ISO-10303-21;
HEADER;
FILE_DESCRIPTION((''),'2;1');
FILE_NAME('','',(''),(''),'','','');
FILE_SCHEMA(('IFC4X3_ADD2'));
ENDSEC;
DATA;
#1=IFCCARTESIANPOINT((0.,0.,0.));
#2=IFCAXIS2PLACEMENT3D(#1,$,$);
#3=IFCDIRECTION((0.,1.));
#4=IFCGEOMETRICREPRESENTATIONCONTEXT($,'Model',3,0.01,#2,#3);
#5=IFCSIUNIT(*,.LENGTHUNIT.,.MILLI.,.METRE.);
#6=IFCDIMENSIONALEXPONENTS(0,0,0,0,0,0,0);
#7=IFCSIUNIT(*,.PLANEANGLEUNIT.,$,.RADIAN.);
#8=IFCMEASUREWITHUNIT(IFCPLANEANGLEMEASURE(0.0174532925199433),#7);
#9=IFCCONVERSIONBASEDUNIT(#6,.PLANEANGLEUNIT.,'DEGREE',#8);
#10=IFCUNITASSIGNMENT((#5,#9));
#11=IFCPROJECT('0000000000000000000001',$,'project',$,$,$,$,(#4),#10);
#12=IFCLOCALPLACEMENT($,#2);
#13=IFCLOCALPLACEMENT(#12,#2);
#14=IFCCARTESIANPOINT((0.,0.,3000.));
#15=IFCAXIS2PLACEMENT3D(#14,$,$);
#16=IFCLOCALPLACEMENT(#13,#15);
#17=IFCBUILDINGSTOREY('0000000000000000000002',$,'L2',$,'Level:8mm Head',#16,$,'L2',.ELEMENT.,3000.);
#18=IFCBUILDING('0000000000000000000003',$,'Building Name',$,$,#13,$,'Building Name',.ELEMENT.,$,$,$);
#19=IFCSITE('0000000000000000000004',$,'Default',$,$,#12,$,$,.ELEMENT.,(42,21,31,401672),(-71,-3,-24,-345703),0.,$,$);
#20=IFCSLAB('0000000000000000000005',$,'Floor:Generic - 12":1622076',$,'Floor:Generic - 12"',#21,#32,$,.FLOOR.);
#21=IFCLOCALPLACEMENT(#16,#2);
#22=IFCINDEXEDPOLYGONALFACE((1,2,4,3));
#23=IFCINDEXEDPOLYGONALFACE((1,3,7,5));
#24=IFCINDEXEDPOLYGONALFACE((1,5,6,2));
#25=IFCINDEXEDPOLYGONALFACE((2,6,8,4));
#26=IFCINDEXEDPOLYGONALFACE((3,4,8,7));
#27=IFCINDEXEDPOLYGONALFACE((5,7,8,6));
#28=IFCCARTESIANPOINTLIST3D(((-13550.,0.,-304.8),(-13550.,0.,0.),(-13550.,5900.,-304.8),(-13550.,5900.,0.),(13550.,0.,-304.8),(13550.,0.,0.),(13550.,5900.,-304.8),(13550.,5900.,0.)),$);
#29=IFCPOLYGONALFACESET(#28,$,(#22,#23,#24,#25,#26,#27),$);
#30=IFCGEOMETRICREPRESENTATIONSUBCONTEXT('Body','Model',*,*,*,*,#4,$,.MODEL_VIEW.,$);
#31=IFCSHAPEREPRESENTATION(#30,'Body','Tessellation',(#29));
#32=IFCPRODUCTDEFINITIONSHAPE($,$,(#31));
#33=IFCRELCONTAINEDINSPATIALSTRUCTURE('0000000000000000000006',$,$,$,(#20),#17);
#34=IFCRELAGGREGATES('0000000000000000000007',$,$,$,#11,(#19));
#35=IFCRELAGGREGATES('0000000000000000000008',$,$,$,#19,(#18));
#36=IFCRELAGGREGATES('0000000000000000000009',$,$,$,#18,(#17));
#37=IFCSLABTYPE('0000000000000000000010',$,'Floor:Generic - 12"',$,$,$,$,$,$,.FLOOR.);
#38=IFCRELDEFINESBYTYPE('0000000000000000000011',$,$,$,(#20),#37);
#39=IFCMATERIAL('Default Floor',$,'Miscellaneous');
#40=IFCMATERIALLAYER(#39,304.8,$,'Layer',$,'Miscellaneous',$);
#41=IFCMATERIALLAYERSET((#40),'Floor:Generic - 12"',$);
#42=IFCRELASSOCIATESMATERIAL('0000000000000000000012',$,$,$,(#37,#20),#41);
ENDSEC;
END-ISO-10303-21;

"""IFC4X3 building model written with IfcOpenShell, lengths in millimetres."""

from ifc_helpers import new_model, entity, si_unit, converted_unit, direction, frame, origin, origin_2d_with_axis, place, context, subcontext, project, spatial, rectangle, extrude, material, layer, layer_set, layer_usage, type_object, element, save


model = new_model("IFC4X3")

# Units and contexts
model_context = context("Model", 3, precision=0.01, world=origin(), true_north=direction((0.0, 1.0)))
body_context = subcontext(model_context, "Body", "Model", "MODEL_VIEW")
ifc_project = project(units=[si_unit("LENGTHUNIT", "METRE", prefix="MILLI"), converted_unit("PLANEANGLEUNIT", "DEGREE", entity("IfcPlaneAngleMeasure", 0.0174532925199433), si_unit("PLANEANGLEUNIT", "RADIAN"), dimensions=[0, 0, 0, 0, 0, 0, 0])], contexts=[model_context])

# Site, building, storey
site_placement = place(None, origin())
site = spatial("IfcSite", under=ifc_project, at=site_placement, Name="Default", CompositionType="ELEMENT", RefLatitude=(42, 21, 31, 401672), RefLongitude=(-71, -3, -24, -345703), RefElevation=0.0)
building_placement = place(site_placement, origin())
building = spatial("IfcBuilding", under=site, at=building_placement, Name="Building Name", LongName="Building Name", CompositionType="ELEMENT")
storey_placement = place(building_placement, frame((0.0, 0.0, 3000.0)))
storey = spatial("IfcBuildingStorey", under=building, at=storey_placement, Name="L2", ObjectType="Level:8mm Head", LongName="L2", CompositionType="ELEMENT", Elevation=3000.0)

# Slab
ifc_material = material(Name="Default Floor", Category="Miscellaneous")
ifc_layer = layer(ifc_material, 304.8, Name="Layer", Category="Miscellaneous")
ifc_layer_set = layer_set([ifc_layer], Name="Floor:Generic - 12\"")
ifc_layer_usage = layer_usage(ifc_layer_set, "AXIS3", "POSITIVE", 0.0)
slab_type = type_object("IfcSlabType", Name="Floor:Generic - 12\"", PredefinedType="FLOOR", material=ifc_layer_set)
slab_placement = place(storey_placement, origin())
element("IfcSlab", 1, at=slab_placement, inside=storey, type_object=slab_type, material=ifc_layer_usage, Name="Floor:Generic - 12\":1622076", ObjectType="Floor:Generic - 12\"", PredefinedType="FLOOR", context=body_context, shape_type="SweptSolid", body=[
    extrude(rectangle(XDim=5900.0, YDim=27100.0, at=origin_2d_with_axis()), frame((0.0, 2950.0, 0.0), z_axis=(0.0, 0.0, -1.0), x_axis=(0.0, 1.0, 0.0)), (0.0, 0.0, 1.0), 304.8),
])

save(model, "model.ifc")
